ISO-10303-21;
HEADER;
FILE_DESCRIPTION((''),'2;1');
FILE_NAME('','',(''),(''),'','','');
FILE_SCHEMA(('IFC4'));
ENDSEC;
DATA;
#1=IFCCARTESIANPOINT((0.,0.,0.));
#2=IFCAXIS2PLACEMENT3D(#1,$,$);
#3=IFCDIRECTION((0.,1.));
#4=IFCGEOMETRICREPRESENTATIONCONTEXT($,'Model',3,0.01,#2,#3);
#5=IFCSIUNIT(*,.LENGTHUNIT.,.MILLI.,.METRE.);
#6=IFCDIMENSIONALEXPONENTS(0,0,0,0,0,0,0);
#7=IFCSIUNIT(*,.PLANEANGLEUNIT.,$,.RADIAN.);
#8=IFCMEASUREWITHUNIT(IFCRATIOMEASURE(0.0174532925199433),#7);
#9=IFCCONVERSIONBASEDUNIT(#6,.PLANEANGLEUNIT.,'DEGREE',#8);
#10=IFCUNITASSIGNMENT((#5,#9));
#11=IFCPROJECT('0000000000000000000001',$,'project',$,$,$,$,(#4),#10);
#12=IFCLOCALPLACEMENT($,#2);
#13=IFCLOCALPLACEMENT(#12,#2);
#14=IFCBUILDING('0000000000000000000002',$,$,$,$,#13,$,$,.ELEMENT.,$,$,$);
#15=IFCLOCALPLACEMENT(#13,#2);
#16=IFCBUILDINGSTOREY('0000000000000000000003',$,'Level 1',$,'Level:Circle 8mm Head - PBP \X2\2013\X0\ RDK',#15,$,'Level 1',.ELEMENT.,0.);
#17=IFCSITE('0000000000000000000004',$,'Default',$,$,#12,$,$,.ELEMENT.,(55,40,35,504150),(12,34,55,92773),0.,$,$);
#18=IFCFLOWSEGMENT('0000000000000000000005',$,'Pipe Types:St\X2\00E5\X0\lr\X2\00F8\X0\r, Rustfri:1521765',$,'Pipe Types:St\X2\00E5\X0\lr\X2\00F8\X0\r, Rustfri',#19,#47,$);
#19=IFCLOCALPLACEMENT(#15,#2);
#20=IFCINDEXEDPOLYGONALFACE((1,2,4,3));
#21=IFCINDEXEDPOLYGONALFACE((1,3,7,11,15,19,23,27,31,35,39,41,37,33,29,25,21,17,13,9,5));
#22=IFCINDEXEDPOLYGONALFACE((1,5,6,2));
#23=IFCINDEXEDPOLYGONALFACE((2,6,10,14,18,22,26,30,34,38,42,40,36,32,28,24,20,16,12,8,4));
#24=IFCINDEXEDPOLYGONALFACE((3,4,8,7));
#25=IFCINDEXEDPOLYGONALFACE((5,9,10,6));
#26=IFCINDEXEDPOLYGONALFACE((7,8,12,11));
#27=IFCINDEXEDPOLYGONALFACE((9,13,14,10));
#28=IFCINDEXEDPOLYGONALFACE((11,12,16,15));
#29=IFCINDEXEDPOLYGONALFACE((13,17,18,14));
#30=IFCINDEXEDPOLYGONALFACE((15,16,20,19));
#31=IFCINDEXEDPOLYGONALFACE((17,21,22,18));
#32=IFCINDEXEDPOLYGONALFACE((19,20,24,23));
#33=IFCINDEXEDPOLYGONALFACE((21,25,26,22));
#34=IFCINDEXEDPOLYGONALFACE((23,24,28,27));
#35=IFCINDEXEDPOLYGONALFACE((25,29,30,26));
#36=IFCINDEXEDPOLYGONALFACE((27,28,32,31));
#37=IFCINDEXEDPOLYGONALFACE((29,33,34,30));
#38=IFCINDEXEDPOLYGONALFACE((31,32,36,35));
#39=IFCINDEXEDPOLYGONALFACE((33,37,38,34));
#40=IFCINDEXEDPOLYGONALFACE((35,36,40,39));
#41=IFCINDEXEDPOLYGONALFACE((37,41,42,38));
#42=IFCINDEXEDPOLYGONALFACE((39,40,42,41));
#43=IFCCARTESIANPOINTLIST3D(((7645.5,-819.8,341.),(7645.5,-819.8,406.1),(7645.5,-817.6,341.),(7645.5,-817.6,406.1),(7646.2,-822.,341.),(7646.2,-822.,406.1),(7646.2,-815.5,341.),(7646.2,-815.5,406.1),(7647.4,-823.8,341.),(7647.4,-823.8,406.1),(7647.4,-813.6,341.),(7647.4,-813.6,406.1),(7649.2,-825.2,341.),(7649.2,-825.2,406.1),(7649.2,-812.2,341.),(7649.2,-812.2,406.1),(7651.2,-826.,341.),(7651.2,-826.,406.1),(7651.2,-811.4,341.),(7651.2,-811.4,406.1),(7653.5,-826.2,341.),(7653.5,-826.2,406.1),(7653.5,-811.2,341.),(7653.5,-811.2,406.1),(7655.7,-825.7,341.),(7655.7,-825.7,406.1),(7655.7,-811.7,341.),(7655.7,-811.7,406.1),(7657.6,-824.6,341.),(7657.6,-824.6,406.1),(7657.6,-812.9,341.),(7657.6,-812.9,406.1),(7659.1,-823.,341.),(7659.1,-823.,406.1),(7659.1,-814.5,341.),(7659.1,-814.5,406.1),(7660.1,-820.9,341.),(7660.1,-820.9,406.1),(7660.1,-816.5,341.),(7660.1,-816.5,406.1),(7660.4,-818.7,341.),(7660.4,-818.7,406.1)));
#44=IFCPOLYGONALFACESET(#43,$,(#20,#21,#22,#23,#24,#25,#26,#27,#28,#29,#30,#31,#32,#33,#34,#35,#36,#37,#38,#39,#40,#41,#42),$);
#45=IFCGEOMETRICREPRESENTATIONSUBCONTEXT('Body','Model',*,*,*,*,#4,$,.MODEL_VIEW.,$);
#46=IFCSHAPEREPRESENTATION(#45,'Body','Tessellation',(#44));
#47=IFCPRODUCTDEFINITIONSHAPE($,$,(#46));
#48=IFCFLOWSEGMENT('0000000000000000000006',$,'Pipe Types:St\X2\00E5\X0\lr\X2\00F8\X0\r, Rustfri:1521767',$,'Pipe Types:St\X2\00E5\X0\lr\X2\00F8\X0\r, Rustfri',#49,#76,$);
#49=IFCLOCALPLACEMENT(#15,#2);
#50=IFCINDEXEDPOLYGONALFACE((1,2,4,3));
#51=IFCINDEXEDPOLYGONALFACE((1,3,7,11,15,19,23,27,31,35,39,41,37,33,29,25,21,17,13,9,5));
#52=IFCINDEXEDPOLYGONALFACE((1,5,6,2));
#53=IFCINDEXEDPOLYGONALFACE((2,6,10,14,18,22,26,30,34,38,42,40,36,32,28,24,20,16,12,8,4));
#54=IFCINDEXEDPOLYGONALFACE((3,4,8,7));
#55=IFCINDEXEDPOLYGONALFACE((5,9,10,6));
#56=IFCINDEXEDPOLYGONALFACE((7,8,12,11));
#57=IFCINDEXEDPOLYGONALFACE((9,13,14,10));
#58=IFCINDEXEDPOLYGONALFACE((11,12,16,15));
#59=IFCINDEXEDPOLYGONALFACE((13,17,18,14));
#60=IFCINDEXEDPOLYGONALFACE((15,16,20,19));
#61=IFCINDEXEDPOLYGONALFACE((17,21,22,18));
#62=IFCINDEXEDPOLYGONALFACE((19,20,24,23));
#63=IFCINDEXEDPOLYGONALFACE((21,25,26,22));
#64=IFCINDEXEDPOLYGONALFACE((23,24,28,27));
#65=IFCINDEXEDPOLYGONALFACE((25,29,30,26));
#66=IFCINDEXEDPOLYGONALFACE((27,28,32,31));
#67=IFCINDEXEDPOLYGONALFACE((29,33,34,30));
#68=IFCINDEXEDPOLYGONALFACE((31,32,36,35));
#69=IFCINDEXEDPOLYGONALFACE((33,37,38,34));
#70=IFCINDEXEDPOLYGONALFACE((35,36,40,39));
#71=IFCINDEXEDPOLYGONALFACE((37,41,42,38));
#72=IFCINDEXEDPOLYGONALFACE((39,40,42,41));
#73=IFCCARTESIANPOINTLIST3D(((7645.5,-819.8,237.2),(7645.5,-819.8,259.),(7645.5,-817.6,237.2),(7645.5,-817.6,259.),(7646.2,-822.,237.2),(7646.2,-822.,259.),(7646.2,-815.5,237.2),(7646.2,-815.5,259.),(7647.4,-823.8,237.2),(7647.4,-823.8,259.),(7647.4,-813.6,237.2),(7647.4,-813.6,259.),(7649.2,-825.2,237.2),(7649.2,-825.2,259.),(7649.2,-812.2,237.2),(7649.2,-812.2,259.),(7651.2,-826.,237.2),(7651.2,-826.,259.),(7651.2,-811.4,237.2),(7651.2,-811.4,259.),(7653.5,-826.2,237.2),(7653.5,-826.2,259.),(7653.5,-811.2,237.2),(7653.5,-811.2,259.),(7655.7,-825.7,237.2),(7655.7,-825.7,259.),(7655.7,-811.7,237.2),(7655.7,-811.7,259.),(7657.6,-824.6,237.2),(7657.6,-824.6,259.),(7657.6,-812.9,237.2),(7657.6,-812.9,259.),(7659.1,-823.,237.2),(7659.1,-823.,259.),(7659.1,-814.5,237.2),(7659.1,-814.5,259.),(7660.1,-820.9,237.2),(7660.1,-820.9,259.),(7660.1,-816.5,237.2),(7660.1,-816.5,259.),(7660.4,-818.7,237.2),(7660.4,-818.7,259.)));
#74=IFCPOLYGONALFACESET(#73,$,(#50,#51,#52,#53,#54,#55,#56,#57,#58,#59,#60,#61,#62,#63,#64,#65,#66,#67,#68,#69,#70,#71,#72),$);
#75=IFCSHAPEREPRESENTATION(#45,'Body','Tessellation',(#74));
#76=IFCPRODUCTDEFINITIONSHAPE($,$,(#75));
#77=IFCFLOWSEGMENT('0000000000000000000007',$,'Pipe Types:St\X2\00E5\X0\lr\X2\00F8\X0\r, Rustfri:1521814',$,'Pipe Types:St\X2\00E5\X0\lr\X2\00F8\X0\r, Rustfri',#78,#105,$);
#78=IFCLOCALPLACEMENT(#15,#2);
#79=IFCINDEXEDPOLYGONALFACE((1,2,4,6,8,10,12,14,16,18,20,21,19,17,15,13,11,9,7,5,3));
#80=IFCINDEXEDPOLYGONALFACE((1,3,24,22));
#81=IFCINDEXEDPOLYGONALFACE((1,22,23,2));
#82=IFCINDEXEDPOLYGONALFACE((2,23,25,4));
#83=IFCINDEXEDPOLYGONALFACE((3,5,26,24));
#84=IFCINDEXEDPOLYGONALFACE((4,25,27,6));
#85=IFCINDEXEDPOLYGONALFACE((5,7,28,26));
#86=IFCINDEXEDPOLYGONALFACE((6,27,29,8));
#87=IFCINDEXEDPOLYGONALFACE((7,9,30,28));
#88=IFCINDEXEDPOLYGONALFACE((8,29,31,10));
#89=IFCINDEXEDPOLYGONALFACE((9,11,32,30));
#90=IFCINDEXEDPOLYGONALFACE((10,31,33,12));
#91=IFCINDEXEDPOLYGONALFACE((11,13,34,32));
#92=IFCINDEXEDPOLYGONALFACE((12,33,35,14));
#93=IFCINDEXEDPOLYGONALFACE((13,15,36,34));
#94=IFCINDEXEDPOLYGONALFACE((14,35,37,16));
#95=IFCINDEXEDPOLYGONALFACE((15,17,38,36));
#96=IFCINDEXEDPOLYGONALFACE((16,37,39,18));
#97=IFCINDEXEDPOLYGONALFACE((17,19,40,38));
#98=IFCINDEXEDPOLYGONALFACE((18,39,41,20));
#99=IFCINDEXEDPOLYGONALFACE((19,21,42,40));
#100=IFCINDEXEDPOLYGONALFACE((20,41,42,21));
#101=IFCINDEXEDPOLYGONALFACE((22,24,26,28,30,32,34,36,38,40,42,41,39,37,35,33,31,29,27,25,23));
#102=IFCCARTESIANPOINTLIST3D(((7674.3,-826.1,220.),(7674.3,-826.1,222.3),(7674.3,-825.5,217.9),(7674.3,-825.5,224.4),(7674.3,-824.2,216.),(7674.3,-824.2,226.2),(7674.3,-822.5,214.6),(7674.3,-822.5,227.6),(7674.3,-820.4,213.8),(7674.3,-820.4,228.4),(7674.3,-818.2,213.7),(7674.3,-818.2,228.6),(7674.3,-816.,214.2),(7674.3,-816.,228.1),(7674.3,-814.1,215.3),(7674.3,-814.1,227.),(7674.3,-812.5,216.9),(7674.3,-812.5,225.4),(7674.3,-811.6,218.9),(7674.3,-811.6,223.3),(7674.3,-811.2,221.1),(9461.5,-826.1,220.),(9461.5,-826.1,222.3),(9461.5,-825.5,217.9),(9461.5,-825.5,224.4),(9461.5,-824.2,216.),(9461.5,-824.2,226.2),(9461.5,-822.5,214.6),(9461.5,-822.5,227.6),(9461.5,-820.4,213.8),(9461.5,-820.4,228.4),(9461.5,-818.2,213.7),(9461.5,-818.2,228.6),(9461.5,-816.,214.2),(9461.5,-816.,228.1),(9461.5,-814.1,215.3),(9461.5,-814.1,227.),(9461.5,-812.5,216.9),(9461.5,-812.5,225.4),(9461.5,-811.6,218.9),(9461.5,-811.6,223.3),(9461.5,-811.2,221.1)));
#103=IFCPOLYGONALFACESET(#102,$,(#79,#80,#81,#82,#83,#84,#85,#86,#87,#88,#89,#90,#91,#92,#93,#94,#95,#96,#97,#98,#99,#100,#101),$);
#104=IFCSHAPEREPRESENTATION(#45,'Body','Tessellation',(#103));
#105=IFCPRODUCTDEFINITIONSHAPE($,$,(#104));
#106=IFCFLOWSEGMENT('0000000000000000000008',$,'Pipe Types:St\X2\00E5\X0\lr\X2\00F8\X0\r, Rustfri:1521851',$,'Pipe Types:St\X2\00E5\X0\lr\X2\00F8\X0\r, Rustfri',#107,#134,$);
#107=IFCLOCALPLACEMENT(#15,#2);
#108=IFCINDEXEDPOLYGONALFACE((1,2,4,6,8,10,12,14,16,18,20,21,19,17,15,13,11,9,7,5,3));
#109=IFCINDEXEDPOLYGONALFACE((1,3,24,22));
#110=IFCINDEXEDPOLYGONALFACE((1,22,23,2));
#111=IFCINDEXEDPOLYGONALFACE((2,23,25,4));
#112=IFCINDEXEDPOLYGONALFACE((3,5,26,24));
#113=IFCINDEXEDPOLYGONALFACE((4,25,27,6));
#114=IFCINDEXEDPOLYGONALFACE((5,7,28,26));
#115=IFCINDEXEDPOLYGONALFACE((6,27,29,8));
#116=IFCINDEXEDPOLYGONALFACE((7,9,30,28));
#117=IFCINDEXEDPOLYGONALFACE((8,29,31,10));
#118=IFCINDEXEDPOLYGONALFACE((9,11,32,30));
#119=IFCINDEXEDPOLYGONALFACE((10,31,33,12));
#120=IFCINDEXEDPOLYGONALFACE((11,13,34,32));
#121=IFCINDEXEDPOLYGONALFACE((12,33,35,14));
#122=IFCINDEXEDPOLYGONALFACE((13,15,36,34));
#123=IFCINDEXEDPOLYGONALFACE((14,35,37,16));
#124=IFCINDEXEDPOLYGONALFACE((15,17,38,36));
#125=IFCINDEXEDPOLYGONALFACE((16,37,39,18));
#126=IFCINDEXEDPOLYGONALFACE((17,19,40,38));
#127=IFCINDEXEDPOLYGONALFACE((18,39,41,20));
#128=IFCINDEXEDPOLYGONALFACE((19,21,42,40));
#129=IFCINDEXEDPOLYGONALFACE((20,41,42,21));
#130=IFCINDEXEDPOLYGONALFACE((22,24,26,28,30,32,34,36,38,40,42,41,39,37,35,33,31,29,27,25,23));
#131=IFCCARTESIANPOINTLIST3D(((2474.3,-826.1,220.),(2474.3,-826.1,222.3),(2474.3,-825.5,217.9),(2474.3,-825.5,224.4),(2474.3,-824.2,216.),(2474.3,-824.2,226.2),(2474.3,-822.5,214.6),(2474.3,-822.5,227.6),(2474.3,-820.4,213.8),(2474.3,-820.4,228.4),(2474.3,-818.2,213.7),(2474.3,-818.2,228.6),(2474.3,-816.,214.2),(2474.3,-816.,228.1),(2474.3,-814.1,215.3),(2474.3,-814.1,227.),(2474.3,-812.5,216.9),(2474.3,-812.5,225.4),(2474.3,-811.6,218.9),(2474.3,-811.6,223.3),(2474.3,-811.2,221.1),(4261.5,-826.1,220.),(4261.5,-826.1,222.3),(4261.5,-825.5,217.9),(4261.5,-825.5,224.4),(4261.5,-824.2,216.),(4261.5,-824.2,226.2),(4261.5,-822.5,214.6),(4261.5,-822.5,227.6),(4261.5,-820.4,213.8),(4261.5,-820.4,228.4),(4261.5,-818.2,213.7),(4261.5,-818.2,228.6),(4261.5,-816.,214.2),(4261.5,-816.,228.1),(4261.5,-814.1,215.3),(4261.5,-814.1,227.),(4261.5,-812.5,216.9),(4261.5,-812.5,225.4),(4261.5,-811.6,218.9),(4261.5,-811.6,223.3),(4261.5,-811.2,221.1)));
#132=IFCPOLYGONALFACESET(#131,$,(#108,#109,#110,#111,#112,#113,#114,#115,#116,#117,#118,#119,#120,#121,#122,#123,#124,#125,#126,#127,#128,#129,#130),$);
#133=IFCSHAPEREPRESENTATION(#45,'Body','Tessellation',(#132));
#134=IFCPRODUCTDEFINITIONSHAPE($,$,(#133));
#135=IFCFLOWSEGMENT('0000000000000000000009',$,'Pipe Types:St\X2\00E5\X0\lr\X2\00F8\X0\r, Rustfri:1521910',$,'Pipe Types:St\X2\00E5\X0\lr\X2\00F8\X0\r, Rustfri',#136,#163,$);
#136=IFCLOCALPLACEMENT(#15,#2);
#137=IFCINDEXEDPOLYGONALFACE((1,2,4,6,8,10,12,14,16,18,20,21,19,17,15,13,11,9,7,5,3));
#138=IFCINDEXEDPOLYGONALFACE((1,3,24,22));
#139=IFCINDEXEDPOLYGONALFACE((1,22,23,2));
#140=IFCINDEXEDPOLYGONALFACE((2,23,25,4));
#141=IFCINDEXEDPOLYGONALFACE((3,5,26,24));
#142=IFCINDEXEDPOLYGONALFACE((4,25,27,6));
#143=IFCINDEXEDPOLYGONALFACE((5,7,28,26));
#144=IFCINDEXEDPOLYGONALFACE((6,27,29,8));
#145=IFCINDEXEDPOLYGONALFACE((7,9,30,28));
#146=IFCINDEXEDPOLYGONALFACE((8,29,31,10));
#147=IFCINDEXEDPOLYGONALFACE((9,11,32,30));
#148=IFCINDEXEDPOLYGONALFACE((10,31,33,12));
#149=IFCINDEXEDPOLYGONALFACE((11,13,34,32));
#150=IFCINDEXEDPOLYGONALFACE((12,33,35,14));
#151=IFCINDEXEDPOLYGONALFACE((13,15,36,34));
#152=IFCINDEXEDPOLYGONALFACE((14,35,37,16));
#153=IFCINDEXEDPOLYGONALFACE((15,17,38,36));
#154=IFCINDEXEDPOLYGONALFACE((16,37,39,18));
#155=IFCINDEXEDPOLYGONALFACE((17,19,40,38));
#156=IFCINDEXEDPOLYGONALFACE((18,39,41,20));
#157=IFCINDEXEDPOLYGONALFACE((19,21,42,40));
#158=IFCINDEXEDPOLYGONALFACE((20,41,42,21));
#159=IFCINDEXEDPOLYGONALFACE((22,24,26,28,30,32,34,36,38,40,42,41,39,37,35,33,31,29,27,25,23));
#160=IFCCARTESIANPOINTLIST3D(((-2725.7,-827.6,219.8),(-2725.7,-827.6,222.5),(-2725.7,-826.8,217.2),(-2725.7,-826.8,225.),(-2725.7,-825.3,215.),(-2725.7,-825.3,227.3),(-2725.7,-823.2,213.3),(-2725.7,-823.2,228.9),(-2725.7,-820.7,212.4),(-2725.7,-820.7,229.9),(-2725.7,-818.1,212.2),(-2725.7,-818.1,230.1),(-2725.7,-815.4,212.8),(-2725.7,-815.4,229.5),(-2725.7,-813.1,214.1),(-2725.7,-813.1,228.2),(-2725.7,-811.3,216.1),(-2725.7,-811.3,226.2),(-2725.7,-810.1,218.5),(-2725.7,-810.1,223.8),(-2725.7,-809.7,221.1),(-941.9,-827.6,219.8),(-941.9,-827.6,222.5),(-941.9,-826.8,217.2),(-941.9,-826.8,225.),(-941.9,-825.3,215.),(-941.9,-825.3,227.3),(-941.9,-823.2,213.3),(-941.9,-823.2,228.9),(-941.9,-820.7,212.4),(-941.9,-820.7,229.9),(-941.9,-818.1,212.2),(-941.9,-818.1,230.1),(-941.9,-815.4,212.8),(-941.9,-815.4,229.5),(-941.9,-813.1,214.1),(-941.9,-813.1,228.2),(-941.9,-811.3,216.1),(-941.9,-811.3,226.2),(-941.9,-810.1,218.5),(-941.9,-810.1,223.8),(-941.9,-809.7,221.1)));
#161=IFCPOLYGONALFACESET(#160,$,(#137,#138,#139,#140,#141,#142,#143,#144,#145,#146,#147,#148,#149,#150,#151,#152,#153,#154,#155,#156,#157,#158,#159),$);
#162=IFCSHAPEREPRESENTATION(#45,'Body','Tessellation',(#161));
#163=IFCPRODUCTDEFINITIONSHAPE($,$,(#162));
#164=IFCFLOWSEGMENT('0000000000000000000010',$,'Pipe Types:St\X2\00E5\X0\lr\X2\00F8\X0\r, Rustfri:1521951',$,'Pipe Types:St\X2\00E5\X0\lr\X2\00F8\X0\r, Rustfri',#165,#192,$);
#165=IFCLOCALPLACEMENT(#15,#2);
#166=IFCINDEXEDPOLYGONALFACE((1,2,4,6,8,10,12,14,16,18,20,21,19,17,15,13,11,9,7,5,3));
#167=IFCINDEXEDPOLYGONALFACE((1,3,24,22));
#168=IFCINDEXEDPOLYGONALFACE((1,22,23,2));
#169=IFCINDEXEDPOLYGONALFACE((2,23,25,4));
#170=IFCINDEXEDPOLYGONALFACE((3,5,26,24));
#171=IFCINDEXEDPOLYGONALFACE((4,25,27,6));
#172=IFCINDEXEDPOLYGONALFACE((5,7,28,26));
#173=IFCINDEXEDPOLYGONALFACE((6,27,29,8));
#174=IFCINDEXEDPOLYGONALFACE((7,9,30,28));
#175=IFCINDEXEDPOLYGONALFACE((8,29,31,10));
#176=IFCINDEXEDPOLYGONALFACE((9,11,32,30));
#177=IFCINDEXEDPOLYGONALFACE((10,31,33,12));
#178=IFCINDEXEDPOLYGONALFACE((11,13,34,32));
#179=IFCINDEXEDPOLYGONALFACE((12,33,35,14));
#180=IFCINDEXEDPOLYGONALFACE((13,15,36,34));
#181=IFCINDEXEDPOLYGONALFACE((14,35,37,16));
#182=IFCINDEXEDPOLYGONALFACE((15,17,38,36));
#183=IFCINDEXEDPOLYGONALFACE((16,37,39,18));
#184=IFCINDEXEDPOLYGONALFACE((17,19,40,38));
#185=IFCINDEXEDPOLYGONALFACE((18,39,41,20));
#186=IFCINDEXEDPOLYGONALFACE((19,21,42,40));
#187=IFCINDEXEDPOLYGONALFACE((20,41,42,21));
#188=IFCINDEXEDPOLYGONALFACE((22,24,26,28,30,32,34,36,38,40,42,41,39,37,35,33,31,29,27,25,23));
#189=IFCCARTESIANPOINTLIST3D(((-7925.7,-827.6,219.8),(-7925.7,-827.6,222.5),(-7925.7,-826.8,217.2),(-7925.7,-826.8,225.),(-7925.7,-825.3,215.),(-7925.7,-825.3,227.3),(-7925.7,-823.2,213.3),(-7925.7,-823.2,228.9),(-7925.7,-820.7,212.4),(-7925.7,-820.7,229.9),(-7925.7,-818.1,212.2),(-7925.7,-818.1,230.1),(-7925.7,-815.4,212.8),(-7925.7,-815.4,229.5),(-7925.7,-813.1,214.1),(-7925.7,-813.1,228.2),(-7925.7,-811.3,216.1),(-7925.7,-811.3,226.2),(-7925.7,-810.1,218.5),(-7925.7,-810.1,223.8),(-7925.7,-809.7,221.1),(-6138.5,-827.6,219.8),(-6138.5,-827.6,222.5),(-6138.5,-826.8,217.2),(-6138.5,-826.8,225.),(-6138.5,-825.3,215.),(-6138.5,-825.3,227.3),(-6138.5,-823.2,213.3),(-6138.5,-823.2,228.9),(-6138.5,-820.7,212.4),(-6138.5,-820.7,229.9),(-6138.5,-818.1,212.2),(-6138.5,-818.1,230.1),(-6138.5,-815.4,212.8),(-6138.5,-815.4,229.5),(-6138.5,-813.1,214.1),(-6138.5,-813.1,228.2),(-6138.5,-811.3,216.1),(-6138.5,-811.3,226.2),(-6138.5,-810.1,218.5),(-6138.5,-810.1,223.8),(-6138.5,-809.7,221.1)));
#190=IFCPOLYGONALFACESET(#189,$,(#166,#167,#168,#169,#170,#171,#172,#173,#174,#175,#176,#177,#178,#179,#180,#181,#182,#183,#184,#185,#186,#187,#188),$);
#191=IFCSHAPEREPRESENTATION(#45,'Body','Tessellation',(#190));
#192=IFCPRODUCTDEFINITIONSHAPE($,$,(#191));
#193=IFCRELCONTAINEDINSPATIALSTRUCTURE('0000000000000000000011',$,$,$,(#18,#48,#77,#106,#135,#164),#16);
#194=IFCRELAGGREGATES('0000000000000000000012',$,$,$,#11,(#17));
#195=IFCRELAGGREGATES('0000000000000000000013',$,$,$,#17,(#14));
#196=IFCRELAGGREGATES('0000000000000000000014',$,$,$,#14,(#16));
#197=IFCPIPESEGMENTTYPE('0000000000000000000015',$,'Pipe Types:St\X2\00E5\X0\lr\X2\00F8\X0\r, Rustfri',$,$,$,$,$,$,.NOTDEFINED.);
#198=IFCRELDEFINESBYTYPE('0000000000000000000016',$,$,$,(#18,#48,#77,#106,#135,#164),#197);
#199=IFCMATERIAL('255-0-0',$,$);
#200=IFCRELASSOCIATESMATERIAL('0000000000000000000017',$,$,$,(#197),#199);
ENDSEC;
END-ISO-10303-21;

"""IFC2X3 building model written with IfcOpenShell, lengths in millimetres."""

from ifc_helpers import new_model, entity, si_unit, converted_unit, direction, frame, frame_2d, origin, origin_2d_with_axis, place, context, subcontext, project, spatial, circle, extrude, material, type_object, element, save


model = new_model("IFC2X3")

# Units and contexts
model_context = context("Model", 3, precision=0.01, world=origin(), true_north=direction((0.0, 1.0)))
body_context = subcontext(model_context, "Body", "Model", "MODEL_VIEW")
ifc_project = project(units=[si_unit("LENGTHUNIT", "METRE", prefix="MILLI"), converted_unit("PLANEANGLEUNIT", "DEGREE", entity("IfcRatioMeasure", 0.0174532925199433), si_unit("PLANEANGLEUNIT", "RADIAN"), dimensions=[0, 0, 0, 0, 0, 0, 0])], contexts=[model_context])

# Site, building, storey
site_placement = place(None, origin())
site = spatial("IfcSite", under=ifc_project, at=site_placement, Name="Default", CompositionType="ELEMENT", RefLatitude=(55, 40, 35, 504150), RefLongitude=(12, 34, 55, 92773), RefElevation=0.0)
building_placement = place(site_placement, origin())
building = spatial("IfcBuilding", under=site, at=building_placement, CompositionType="ELEMENT")
storey_placement = place(building_placement, origin())
storey = spatial("IfcBuildingStorey", under=building, at=storey_placement, Name="Level 1", ObjectType="Level:Circle 8mm Head - PBP – RDK", LongName="Level 1", CompositionType="ELEMENT", Elevation=0.0)

# Flow segments
ifc_material_1 = material(Name="255-0-0")
pipe_segment_type = type_object("IfcPipeSegmentType", Name="Pipe Types:Stålrør, Rustfri", PredefinedType="NOTDEFINED", material=ifc_material_1)
flow_segment_1_placement = place(storey_placement, origin())
element("IfcFlowSegment", 1, at=flow_segment_1_placement, inside=storey, type_object=pipe_segment_type, Name="Pipe Types:Stålrør, Rustfri:1521765", ObjectType="Pipe Types:Stålrør, Rustfri", context=body_context, shape_type="SweptSolid", body=[
    extrude(circle(Radius=7.5, at=origin_2d_with_axis()), frame((7652.9, -818.7, 341.0)), (0.0, 0.0, 1.0), 65.1),
])
flow_segment_2_placement = place(storey_placement, origin())
element("IfcFlowSegment", 2, at=flow_segment_2_placement, inside=storey, type_object=pipe_segment_type, Name="Pipe Types:Stålrør, Rustfri:1521767", ObjectType="Pipe Types:Stålrør, Rustfri", context=body_context, shape_type="SweptSolid", body=[
    extrude(circle(Radius=7.5, at=origin_2d_with_axis()), frame((7652.9, -818.7, 237.2)), (0.0, 0.0, 1.0), 21.8),
])
flow_segment_3_placement = place(storey_placement, origin())
element("IfcFlowSegment", 3, at=flow_segment_3_placement, inside=storey, type_object=pipe_segment_type, Name="Pipe Types:Stålrør, Rustfri:1521814", ObjectType="Pipe Types:Stålrør, Rustfri", context=body_context, shape_type="SweptSolid", body=[
    extrude(circle(Radius=7.5, at=frame_2d((0.0, 0.0), x_axis=(1.0, 0.0))), frame((7674.3, -818.7, 221.1), z_axis=(1.0, 0.0, 0.0), x_axis=(0.0, 1.0, 0.0)), (0.0, 0.0, 1.0), 1787.2),
])
flow_segment_4_placement = place(storey_placement, origin())
element("IfcFlowSegment", 4, at=flow_segment_4_placement, inside=storey, type_object=pipe_segment_type, Name="Pipe Types:Stålrør, Rustfri:1521851", ObjectType="Pipe Types:Stålrør, Rustfri", context=body_context, shape_type="SweptSolid", body=[
    extrude(circle(Radius=7.5, at=frame_2d((0.0, 0.0), x_axis=(1.0, 0.0))), frame((2474.3, -818.7, 221.1), z_axis=(1.0, 0.0, 0.0), x_axis=(0.0, 1.0, 0.0)), (0.0, 0.0, 1.0), 1787.2),
])
flow_segment_5_placement = place(storey_placement, origin())
element("IfcFlowSegment", 5, at=flow_segment_5_placement, inside=storey, type_object=pipe_segment_type, Name="Pipe Types:Stålrør, Rustfri:1521910", ObjectType="Pipe Types:Stålrør, Rustfri", context=body_context, shape_type="SweptSolid", body=[
    extrude(circle(Radius=9.0, at=frame_2d((0.0, 0.0), x_axis=(1.0, 0.0))), frame((-2725.7, -818.7, 221.1), z_axis=(1.0, 0.0, 0.0), x_axis=(0.0, 1.0, 0.0)), (0.0, 0.0, 1.0), 1783.8),
])
flow_segment_6_placement = place(storey_placement, origin())
element("IfcFlowSegment", 6, at=flow_segment_6_placement, inside=storey, type_object=pipe_segment_type, Name="Pipe Types:Stålrør, Rustfri:1521951", ObjectType="Pipe Types:Stålrør, Rustfri", context=body_context, shape_type="SweptSolid", body=[
    extrude(circle(Radius=9.0, at=frame_2d((0.0, 0.0), x_axis=(1.0, 0.0))), frame((-7925.7, -818.7, 221.1), z_axis=(1.0, 0.0, 0.0), x_axis=(0.0, 1.0, 0.0)), (0.0, 0.0, 1.0), 1787.2),
])

save(model, "model.ifc")
